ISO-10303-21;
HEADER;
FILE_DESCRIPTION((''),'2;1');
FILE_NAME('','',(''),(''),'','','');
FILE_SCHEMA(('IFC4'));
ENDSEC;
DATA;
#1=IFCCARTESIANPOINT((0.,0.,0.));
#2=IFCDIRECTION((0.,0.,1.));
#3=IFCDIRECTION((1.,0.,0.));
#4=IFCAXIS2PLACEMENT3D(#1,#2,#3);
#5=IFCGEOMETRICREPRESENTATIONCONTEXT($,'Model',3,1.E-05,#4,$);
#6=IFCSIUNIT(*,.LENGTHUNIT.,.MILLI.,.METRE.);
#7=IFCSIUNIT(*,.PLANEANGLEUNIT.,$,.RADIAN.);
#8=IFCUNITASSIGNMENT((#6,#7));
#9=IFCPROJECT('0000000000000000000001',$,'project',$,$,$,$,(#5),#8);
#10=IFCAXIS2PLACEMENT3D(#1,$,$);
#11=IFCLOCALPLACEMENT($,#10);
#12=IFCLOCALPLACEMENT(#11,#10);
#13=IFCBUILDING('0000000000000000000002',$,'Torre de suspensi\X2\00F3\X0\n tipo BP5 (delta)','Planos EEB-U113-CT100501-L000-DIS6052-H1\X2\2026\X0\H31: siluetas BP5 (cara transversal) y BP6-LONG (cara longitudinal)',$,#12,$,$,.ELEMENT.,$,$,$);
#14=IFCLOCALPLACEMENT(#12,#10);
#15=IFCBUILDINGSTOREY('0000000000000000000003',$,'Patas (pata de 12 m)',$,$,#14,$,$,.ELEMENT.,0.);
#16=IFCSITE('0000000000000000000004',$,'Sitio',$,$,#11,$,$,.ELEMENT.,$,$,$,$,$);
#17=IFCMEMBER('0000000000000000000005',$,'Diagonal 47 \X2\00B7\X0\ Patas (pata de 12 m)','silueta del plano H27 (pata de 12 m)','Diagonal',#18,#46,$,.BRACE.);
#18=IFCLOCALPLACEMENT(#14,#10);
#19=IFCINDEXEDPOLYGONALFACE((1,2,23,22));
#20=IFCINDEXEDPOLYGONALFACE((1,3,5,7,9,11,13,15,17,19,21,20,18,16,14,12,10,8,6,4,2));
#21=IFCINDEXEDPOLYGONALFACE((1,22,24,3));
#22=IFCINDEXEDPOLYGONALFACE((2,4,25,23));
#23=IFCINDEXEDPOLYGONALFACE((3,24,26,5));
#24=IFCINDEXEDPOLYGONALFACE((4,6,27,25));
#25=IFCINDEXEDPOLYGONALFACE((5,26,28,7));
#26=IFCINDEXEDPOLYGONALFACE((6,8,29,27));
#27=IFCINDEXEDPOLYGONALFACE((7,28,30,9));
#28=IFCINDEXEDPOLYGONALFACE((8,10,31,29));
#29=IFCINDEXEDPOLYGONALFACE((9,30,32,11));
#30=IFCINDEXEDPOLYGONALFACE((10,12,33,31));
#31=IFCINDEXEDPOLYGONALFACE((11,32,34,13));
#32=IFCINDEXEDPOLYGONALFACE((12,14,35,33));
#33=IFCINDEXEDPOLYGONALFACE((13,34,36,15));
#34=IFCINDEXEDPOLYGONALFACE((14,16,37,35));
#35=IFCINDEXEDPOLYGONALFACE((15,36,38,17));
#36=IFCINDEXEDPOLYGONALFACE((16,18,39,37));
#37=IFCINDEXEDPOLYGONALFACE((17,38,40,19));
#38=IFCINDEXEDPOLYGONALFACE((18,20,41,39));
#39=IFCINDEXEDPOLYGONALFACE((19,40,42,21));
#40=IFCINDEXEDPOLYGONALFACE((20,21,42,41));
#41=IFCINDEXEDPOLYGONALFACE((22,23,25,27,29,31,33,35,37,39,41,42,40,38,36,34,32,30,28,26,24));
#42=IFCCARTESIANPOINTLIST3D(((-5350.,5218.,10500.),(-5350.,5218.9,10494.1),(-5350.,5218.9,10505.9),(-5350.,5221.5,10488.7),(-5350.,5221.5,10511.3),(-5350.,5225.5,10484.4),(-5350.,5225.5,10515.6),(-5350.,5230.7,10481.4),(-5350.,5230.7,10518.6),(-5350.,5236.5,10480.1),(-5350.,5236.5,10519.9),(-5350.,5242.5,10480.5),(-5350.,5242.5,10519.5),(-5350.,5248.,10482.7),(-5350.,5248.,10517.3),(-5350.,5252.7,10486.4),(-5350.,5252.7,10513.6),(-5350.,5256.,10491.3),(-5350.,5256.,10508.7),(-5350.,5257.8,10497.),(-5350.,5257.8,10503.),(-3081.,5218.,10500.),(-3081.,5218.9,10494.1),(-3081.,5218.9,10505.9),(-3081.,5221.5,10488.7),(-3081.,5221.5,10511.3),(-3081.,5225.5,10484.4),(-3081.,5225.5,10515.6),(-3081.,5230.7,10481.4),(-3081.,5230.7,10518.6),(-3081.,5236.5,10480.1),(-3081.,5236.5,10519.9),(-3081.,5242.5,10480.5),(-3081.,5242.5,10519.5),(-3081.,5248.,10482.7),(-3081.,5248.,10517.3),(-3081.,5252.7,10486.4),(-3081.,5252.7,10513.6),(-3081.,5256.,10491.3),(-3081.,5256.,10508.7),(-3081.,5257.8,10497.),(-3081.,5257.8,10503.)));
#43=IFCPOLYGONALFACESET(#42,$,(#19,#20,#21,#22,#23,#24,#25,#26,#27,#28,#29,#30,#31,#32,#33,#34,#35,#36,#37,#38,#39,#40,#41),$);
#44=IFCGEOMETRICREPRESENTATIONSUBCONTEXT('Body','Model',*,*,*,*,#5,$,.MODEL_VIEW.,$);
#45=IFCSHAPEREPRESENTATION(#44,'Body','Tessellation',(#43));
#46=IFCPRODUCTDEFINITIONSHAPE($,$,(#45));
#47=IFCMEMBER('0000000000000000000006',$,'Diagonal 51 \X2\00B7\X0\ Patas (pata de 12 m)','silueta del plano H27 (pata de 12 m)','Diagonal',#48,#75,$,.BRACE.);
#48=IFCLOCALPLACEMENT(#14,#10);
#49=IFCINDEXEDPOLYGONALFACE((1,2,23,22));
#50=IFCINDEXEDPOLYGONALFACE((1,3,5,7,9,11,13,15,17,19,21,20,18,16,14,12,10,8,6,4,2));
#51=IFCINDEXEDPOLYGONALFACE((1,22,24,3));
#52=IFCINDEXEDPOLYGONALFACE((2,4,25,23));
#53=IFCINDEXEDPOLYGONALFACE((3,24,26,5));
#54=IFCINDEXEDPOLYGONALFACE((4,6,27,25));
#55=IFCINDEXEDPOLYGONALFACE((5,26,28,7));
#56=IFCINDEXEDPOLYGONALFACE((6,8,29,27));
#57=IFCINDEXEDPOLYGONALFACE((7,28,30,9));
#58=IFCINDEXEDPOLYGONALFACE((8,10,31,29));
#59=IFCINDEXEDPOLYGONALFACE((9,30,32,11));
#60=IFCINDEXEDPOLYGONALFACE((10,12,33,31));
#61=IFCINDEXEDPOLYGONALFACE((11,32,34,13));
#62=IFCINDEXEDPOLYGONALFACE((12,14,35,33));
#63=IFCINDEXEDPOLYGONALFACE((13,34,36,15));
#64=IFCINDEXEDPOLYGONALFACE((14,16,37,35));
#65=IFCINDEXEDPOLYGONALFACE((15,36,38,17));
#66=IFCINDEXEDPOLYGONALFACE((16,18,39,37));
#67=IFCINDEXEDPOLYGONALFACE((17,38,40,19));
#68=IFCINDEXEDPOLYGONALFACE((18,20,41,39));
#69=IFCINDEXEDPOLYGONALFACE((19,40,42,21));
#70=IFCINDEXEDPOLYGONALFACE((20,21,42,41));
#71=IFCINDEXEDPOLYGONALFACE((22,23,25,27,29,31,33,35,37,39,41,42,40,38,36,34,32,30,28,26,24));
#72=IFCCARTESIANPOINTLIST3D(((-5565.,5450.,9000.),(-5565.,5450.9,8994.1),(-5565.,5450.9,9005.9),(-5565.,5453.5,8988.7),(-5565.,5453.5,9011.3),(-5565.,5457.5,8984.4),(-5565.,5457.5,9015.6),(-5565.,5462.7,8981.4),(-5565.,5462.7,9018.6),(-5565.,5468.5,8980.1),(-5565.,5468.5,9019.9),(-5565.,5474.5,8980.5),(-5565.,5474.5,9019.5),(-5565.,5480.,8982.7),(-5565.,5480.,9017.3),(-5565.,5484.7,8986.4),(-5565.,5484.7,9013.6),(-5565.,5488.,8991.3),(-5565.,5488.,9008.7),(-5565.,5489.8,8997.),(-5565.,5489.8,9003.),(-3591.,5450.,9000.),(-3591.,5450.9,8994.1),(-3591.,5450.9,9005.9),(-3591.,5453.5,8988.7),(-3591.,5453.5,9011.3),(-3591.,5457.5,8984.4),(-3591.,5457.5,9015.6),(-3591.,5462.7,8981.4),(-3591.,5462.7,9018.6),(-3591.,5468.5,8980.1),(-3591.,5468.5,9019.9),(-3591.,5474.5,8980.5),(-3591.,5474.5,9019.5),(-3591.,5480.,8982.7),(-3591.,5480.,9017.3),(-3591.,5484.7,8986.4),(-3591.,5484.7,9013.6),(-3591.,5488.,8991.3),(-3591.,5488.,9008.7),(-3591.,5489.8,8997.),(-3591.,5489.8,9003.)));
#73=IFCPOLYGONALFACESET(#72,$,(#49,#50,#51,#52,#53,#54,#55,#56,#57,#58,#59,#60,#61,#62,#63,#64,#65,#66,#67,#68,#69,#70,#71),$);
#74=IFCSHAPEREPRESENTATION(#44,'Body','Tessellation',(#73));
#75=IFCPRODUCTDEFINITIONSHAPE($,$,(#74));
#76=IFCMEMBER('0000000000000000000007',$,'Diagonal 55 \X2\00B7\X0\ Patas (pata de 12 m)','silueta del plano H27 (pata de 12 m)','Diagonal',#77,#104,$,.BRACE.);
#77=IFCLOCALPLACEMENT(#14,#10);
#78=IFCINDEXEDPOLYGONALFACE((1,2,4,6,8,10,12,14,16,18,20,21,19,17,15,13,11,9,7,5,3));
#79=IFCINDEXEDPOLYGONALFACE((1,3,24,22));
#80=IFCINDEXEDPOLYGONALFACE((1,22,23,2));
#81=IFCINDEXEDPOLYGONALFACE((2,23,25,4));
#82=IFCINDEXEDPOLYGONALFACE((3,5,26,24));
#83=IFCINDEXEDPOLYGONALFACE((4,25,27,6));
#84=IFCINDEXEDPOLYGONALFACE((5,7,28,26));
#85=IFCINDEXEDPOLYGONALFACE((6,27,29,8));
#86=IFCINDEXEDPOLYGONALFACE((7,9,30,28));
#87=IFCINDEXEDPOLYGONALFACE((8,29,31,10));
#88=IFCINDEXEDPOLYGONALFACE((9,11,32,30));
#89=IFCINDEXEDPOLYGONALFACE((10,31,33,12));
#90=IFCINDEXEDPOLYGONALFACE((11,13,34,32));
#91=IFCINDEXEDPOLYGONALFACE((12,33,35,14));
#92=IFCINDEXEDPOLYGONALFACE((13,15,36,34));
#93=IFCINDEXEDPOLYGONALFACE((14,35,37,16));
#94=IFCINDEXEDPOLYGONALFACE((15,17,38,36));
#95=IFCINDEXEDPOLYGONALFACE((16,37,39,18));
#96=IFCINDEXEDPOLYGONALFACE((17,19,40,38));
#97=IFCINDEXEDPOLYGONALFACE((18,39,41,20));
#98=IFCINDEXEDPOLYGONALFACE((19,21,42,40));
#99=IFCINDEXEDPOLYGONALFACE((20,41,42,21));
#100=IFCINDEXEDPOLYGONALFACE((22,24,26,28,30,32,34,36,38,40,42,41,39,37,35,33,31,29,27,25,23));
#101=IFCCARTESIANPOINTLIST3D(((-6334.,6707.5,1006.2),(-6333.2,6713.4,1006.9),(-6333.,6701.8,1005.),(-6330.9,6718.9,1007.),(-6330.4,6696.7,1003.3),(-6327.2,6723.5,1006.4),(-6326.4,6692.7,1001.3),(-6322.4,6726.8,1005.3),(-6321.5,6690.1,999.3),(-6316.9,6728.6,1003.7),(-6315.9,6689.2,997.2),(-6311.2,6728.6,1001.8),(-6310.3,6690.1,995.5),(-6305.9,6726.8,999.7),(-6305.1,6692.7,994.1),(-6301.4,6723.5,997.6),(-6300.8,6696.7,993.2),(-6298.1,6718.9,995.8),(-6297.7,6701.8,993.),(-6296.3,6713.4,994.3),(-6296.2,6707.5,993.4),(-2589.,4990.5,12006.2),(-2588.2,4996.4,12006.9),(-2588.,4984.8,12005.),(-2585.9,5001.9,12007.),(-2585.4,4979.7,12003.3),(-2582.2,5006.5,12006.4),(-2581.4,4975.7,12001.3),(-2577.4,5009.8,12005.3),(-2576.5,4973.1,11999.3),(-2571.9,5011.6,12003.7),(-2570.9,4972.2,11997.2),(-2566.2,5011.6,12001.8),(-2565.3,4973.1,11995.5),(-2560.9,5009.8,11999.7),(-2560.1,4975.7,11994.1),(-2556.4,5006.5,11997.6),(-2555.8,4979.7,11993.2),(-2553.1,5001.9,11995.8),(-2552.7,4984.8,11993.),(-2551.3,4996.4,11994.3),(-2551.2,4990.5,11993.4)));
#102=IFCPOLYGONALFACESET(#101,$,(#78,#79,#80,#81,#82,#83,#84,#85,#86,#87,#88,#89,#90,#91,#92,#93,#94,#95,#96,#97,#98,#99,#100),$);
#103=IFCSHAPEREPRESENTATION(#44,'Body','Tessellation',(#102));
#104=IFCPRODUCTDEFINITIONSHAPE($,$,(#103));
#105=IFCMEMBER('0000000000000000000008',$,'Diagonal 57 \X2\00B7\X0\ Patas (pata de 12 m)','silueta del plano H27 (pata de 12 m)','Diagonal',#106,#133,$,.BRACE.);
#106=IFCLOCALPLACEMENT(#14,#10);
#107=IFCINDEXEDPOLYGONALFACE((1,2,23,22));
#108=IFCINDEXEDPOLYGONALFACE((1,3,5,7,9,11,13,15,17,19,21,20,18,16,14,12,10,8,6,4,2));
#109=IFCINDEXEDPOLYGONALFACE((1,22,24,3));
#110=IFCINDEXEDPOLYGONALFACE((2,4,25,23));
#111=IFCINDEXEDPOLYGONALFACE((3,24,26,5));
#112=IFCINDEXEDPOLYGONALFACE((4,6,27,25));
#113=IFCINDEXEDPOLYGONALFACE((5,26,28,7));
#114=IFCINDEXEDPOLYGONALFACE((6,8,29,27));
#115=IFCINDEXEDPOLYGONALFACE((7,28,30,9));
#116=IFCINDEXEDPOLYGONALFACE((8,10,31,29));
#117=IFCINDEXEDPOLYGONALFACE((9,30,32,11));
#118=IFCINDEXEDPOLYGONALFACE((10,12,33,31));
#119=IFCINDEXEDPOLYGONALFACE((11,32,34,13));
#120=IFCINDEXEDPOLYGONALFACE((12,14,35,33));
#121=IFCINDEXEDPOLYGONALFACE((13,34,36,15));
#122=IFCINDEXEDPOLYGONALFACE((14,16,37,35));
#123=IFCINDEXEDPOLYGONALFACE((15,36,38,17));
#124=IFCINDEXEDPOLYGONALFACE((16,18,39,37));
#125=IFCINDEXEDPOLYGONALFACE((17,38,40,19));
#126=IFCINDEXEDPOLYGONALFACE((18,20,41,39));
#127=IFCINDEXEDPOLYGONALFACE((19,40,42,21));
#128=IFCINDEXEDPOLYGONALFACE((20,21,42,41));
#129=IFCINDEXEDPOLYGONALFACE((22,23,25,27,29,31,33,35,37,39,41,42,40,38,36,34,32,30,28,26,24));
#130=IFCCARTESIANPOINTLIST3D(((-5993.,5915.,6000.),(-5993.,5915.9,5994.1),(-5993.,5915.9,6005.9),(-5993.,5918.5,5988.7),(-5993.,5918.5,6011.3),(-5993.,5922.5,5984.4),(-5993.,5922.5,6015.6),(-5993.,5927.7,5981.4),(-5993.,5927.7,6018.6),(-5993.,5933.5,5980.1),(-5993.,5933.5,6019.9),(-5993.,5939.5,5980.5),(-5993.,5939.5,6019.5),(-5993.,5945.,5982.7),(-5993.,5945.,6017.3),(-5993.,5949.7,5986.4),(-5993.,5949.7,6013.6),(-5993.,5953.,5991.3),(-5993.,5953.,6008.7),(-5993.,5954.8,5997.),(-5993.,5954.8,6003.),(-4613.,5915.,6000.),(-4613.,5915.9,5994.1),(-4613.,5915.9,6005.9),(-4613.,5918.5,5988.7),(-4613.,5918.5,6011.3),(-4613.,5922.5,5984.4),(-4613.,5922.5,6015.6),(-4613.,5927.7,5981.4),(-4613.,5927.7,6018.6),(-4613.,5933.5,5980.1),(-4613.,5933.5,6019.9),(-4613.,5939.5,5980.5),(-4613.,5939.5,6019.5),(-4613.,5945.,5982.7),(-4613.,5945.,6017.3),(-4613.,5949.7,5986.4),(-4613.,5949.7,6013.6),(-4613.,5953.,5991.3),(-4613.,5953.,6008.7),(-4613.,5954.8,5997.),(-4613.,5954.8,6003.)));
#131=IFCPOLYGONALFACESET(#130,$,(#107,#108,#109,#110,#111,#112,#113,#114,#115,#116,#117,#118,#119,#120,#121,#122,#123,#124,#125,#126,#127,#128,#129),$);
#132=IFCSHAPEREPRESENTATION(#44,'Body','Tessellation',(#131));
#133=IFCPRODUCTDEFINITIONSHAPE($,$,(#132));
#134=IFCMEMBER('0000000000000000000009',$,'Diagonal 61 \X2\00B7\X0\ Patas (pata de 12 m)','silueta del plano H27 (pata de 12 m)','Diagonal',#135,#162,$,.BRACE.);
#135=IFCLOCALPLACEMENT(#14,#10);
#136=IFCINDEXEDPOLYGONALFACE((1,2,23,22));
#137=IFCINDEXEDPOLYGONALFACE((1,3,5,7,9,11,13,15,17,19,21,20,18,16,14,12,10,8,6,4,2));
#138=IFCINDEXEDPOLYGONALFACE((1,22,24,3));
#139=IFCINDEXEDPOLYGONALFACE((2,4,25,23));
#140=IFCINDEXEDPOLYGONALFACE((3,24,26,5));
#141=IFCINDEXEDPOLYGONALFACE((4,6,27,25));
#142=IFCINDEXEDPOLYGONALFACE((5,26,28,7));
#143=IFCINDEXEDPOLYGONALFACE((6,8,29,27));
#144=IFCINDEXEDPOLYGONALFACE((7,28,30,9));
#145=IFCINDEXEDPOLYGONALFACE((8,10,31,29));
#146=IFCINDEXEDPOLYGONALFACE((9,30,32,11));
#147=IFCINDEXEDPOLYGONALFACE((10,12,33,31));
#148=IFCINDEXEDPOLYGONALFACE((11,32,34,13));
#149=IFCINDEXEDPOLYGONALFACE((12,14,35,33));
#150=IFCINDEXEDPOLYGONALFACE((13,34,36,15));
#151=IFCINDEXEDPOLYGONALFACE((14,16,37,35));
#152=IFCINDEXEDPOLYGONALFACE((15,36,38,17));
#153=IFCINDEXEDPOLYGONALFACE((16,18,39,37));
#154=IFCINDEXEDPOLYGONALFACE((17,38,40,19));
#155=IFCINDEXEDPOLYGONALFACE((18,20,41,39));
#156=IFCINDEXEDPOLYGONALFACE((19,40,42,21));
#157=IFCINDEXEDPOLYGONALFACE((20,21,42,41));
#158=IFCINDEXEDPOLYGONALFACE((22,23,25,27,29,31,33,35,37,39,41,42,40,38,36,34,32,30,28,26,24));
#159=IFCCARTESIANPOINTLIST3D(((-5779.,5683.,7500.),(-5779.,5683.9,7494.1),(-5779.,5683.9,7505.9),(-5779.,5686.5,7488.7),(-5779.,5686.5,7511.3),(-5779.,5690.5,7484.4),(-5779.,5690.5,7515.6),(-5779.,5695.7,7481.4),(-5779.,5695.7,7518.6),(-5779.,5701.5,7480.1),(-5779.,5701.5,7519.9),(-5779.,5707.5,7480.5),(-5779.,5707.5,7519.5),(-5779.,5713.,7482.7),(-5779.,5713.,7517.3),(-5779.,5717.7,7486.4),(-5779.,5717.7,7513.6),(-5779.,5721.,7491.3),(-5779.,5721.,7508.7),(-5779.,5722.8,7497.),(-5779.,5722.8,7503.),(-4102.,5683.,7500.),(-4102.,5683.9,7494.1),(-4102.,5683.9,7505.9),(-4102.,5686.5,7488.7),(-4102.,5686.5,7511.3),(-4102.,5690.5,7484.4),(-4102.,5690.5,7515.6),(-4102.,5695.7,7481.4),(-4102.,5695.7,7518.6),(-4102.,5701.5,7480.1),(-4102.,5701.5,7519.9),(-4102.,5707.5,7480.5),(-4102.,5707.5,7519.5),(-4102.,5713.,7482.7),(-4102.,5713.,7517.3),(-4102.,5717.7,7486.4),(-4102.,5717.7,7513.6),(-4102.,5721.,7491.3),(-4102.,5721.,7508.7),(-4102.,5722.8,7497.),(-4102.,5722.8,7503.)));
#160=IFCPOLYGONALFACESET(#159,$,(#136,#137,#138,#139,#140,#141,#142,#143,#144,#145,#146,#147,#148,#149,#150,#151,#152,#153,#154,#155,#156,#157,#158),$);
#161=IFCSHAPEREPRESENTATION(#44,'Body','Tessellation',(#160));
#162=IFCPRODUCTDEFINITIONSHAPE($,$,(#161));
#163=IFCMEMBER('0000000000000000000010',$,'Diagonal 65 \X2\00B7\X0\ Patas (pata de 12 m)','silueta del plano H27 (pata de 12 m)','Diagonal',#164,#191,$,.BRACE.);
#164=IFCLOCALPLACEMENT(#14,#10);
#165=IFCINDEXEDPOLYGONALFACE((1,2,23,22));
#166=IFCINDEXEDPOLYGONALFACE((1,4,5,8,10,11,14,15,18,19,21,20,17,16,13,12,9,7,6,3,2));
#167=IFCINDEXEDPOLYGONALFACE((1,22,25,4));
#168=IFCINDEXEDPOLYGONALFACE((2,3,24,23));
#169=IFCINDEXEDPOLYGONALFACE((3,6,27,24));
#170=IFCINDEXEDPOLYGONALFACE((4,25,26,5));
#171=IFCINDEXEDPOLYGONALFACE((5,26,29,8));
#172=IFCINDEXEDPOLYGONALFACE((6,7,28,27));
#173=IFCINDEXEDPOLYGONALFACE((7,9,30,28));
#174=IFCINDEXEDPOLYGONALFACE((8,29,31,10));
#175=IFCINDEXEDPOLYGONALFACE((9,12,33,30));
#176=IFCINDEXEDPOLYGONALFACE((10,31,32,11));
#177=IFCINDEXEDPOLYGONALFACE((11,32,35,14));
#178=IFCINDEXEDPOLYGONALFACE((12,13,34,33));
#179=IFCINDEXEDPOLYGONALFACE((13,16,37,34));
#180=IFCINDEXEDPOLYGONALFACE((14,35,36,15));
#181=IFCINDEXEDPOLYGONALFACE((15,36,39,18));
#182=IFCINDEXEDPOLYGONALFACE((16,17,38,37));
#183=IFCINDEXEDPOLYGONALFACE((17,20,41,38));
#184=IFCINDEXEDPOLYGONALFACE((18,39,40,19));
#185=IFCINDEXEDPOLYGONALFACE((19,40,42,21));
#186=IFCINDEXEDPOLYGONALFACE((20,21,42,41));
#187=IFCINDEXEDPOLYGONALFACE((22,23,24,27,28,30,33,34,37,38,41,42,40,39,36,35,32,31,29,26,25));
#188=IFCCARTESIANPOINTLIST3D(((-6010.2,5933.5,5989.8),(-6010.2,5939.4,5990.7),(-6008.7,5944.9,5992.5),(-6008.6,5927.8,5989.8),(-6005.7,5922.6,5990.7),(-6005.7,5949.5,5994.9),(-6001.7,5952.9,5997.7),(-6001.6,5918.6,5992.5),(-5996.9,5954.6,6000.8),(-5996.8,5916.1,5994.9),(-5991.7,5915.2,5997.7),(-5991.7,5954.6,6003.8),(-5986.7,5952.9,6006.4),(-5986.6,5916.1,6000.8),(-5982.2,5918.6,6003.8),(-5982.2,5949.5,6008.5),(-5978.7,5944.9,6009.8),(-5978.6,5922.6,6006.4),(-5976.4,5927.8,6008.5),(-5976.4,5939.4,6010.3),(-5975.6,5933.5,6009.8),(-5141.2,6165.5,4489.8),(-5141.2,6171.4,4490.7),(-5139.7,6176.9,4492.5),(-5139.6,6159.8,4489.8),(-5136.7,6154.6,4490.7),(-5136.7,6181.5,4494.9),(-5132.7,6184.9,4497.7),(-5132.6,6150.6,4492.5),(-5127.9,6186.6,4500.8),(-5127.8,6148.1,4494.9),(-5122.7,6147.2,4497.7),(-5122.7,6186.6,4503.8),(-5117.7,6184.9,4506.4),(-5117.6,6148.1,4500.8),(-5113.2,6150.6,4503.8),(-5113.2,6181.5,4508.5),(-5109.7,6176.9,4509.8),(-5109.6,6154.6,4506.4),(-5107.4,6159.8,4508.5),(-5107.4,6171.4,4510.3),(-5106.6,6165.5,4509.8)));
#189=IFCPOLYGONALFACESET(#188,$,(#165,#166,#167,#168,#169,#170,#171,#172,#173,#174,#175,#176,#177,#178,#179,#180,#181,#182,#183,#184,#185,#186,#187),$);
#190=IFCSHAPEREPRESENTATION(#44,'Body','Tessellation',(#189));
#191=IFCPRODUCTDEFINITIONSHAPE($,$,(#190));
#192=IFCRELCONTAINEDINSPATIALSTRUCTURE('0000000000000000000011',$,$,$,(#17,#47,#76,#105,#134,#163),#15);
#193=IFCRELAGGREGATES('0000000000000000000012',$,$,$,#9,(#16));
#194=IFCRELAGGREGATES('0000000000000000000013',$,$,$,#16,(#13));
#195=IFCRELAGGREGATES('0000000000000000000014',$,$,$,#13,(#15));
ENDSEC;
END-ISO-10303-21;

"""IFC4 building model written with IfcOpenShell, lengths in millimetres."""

from ifc_helpers import new_model, si_unit, frame, origin, origin_with_axes, place, context, subcontext, project, spatial, circle, extrude, element, save


model = new_model("IFC4")

# Units and contexts
model_context = context("Model", 3, precision=1e-05, world=origin_with_axes())
body_context = subcontext(model_context, "Body", "Model", "MODEL_VIEW")
ifc_project = project(units=[si_unit("LENGTHUNIT", "METRE", prefix="MILLI"), si_unit("PLANEANGLEUNIT", "RADIAN")], contexts=[model_context])

# Site, building, storey
site_placement = place(None, origin())
site = spatial("IfcSite", under=ifc_project, at=site_placement, Name="Sitio", CompositionType="ELEMENT")
building_placement = place(site_placement, origin())
building = spatial("IfcBuilding", under=site, at=building_placement, Name="Torre de suspensión tipo BP5 (delta)", Description="Planos EEB-U113-CT100501-L000-DIS6052-H1…H31: siluetas BP5 (cara transversal) y BP6-LONG (cara longitudinal)", CompositionType="ELEMENT")
storey_placement = place(building_placement, origin())
storey = spatial("IfcBuildingStorey", under=building, at=storey_placement, Name="Patas (pata de 12 m)", CompositionType="ELEMENT", Elevation=0.0)

# Members
member_1_placement = place(storey_placement, frame((-3081.0, 5238.0, 10500.0), z_axis=(-1.0, 0.0, 0.0), x_axis=(0.0, -1.0, 0.0)))
element("IfcMember", 1, at=member_1_placement, inside=storey, Name="Diagonal 47 · Patas (pata de 12 m)", Description="silueta del plano H27 (pata de 12 m)", ObjectType="Diagonal", PredefinedType="BRACE", context=body_context, shape_type="SweptSolid", body=[
    extrude(circle(Radius=20.0), None, (0.0, 0.0, 1.0), 2269.0),
])
member_2_placement = place(storey_placement, frame((-5565.0, 5470.0, 9000.0), z_axis=(1.0, 0.0, 0.0), x_axis=(0.0, -1.0, 0.0)))
element("IfcMember", 2, at=member_2_placement, inside=storey, Name="Diagonal 51 · Patas (pata de 12 m)", Description="silueta del plano H27 (pata de 12 m)", ObjectType="Diagonal", PredefinedType="BRACE", context=body_context, shape_type="SweptSolid", body=[
    extrude(circle(Radius=20.0), None, (0.0, 0.0, 1.0), 1974.0),
])
member_3_placement = place(storey_placement, frame((-2570.0, 4992.0, 12000.0), z_axis=(-0.318827, 0.146175, -0.936473), x_axis=(-0.047111, -0.989259, -0.138375)))
element("IfcMember", 3, at=member_3_placement, inside=storey, Name="Diagonal 55 · Patas (pata de 12 m)", Description="silueta del plano H27 (pata de 12 m)", ObjectType="Diagonal", PredefinedType="BRACE", context=body_context, shape_type="SweptSolid", body=[
    extrude(circle(Radius=20.0), None, (0.0, 0.0, 1.0), 11746.2),
])
member_4_placement = place(storey_placement, frame((-5993.0, 5935.0, 6000.0), z_axis=(1.0, 0.0, 0.0), x_axis=(0.0, -1.0, 0.0)))
element("IfcMember", 4, at=member_4_placement, inside=storey, Name="Diagonal 57 · Patas (pata de 12 m)", Description="silueta del plano H27 (pata de 12 m)", ObjectType="Diagonal", PredefinedType="BRACE", context=body_context, shape_type="SweptSolid", body=[
    extrude(circle(Radius=20.0), None, (0.0, 0.0, 1.0), 1380.0),
])
member_5_placement = place(storey_placement, frame((-5779.0, 5703.0, 7500.0), z_axis=(1.0, 0.0, 0.0), x_axis=(0.0, -1.0, 0.0)))
element("IfcMember", 5, at=member_5_placement, inside=storey, Name="Diagonal 61 · Patas (pata de 12 m)", Description="silueta del plano H27 (pata de 12 m)", ObjectType="Diagonal", PredefinedType="BRACE", context=body_context, shape_type="SweptSolid", body=[
    extrude(circle(Radius=20.0), None, (0.0, 0.0, 1.0), 1677.0),
])
member_6_placement = place(storey_placement, frame((-5124.0, 6167.0, 4500.0), z_axis=(-0.496857, -0.132648, 0.857635), x_axis=(0.066494, -0.991163, -0.114777)))
element("IfcMember", 6, at=member_6_placement, inside=storey, Name="Diagonal 65 · Patas (pata de 12 m)", Description="silueta del plano H27 (pata de 12 m)", ObjectType="Diagonal", PredefinedType="BRACE", context=body_context, shape_type="SweptSolid", body=[
    extrude(circle(Radius=20.0), None, (0.0, 0.0, 1.0), 1749.0),
])

save(model, "model.ifc")
